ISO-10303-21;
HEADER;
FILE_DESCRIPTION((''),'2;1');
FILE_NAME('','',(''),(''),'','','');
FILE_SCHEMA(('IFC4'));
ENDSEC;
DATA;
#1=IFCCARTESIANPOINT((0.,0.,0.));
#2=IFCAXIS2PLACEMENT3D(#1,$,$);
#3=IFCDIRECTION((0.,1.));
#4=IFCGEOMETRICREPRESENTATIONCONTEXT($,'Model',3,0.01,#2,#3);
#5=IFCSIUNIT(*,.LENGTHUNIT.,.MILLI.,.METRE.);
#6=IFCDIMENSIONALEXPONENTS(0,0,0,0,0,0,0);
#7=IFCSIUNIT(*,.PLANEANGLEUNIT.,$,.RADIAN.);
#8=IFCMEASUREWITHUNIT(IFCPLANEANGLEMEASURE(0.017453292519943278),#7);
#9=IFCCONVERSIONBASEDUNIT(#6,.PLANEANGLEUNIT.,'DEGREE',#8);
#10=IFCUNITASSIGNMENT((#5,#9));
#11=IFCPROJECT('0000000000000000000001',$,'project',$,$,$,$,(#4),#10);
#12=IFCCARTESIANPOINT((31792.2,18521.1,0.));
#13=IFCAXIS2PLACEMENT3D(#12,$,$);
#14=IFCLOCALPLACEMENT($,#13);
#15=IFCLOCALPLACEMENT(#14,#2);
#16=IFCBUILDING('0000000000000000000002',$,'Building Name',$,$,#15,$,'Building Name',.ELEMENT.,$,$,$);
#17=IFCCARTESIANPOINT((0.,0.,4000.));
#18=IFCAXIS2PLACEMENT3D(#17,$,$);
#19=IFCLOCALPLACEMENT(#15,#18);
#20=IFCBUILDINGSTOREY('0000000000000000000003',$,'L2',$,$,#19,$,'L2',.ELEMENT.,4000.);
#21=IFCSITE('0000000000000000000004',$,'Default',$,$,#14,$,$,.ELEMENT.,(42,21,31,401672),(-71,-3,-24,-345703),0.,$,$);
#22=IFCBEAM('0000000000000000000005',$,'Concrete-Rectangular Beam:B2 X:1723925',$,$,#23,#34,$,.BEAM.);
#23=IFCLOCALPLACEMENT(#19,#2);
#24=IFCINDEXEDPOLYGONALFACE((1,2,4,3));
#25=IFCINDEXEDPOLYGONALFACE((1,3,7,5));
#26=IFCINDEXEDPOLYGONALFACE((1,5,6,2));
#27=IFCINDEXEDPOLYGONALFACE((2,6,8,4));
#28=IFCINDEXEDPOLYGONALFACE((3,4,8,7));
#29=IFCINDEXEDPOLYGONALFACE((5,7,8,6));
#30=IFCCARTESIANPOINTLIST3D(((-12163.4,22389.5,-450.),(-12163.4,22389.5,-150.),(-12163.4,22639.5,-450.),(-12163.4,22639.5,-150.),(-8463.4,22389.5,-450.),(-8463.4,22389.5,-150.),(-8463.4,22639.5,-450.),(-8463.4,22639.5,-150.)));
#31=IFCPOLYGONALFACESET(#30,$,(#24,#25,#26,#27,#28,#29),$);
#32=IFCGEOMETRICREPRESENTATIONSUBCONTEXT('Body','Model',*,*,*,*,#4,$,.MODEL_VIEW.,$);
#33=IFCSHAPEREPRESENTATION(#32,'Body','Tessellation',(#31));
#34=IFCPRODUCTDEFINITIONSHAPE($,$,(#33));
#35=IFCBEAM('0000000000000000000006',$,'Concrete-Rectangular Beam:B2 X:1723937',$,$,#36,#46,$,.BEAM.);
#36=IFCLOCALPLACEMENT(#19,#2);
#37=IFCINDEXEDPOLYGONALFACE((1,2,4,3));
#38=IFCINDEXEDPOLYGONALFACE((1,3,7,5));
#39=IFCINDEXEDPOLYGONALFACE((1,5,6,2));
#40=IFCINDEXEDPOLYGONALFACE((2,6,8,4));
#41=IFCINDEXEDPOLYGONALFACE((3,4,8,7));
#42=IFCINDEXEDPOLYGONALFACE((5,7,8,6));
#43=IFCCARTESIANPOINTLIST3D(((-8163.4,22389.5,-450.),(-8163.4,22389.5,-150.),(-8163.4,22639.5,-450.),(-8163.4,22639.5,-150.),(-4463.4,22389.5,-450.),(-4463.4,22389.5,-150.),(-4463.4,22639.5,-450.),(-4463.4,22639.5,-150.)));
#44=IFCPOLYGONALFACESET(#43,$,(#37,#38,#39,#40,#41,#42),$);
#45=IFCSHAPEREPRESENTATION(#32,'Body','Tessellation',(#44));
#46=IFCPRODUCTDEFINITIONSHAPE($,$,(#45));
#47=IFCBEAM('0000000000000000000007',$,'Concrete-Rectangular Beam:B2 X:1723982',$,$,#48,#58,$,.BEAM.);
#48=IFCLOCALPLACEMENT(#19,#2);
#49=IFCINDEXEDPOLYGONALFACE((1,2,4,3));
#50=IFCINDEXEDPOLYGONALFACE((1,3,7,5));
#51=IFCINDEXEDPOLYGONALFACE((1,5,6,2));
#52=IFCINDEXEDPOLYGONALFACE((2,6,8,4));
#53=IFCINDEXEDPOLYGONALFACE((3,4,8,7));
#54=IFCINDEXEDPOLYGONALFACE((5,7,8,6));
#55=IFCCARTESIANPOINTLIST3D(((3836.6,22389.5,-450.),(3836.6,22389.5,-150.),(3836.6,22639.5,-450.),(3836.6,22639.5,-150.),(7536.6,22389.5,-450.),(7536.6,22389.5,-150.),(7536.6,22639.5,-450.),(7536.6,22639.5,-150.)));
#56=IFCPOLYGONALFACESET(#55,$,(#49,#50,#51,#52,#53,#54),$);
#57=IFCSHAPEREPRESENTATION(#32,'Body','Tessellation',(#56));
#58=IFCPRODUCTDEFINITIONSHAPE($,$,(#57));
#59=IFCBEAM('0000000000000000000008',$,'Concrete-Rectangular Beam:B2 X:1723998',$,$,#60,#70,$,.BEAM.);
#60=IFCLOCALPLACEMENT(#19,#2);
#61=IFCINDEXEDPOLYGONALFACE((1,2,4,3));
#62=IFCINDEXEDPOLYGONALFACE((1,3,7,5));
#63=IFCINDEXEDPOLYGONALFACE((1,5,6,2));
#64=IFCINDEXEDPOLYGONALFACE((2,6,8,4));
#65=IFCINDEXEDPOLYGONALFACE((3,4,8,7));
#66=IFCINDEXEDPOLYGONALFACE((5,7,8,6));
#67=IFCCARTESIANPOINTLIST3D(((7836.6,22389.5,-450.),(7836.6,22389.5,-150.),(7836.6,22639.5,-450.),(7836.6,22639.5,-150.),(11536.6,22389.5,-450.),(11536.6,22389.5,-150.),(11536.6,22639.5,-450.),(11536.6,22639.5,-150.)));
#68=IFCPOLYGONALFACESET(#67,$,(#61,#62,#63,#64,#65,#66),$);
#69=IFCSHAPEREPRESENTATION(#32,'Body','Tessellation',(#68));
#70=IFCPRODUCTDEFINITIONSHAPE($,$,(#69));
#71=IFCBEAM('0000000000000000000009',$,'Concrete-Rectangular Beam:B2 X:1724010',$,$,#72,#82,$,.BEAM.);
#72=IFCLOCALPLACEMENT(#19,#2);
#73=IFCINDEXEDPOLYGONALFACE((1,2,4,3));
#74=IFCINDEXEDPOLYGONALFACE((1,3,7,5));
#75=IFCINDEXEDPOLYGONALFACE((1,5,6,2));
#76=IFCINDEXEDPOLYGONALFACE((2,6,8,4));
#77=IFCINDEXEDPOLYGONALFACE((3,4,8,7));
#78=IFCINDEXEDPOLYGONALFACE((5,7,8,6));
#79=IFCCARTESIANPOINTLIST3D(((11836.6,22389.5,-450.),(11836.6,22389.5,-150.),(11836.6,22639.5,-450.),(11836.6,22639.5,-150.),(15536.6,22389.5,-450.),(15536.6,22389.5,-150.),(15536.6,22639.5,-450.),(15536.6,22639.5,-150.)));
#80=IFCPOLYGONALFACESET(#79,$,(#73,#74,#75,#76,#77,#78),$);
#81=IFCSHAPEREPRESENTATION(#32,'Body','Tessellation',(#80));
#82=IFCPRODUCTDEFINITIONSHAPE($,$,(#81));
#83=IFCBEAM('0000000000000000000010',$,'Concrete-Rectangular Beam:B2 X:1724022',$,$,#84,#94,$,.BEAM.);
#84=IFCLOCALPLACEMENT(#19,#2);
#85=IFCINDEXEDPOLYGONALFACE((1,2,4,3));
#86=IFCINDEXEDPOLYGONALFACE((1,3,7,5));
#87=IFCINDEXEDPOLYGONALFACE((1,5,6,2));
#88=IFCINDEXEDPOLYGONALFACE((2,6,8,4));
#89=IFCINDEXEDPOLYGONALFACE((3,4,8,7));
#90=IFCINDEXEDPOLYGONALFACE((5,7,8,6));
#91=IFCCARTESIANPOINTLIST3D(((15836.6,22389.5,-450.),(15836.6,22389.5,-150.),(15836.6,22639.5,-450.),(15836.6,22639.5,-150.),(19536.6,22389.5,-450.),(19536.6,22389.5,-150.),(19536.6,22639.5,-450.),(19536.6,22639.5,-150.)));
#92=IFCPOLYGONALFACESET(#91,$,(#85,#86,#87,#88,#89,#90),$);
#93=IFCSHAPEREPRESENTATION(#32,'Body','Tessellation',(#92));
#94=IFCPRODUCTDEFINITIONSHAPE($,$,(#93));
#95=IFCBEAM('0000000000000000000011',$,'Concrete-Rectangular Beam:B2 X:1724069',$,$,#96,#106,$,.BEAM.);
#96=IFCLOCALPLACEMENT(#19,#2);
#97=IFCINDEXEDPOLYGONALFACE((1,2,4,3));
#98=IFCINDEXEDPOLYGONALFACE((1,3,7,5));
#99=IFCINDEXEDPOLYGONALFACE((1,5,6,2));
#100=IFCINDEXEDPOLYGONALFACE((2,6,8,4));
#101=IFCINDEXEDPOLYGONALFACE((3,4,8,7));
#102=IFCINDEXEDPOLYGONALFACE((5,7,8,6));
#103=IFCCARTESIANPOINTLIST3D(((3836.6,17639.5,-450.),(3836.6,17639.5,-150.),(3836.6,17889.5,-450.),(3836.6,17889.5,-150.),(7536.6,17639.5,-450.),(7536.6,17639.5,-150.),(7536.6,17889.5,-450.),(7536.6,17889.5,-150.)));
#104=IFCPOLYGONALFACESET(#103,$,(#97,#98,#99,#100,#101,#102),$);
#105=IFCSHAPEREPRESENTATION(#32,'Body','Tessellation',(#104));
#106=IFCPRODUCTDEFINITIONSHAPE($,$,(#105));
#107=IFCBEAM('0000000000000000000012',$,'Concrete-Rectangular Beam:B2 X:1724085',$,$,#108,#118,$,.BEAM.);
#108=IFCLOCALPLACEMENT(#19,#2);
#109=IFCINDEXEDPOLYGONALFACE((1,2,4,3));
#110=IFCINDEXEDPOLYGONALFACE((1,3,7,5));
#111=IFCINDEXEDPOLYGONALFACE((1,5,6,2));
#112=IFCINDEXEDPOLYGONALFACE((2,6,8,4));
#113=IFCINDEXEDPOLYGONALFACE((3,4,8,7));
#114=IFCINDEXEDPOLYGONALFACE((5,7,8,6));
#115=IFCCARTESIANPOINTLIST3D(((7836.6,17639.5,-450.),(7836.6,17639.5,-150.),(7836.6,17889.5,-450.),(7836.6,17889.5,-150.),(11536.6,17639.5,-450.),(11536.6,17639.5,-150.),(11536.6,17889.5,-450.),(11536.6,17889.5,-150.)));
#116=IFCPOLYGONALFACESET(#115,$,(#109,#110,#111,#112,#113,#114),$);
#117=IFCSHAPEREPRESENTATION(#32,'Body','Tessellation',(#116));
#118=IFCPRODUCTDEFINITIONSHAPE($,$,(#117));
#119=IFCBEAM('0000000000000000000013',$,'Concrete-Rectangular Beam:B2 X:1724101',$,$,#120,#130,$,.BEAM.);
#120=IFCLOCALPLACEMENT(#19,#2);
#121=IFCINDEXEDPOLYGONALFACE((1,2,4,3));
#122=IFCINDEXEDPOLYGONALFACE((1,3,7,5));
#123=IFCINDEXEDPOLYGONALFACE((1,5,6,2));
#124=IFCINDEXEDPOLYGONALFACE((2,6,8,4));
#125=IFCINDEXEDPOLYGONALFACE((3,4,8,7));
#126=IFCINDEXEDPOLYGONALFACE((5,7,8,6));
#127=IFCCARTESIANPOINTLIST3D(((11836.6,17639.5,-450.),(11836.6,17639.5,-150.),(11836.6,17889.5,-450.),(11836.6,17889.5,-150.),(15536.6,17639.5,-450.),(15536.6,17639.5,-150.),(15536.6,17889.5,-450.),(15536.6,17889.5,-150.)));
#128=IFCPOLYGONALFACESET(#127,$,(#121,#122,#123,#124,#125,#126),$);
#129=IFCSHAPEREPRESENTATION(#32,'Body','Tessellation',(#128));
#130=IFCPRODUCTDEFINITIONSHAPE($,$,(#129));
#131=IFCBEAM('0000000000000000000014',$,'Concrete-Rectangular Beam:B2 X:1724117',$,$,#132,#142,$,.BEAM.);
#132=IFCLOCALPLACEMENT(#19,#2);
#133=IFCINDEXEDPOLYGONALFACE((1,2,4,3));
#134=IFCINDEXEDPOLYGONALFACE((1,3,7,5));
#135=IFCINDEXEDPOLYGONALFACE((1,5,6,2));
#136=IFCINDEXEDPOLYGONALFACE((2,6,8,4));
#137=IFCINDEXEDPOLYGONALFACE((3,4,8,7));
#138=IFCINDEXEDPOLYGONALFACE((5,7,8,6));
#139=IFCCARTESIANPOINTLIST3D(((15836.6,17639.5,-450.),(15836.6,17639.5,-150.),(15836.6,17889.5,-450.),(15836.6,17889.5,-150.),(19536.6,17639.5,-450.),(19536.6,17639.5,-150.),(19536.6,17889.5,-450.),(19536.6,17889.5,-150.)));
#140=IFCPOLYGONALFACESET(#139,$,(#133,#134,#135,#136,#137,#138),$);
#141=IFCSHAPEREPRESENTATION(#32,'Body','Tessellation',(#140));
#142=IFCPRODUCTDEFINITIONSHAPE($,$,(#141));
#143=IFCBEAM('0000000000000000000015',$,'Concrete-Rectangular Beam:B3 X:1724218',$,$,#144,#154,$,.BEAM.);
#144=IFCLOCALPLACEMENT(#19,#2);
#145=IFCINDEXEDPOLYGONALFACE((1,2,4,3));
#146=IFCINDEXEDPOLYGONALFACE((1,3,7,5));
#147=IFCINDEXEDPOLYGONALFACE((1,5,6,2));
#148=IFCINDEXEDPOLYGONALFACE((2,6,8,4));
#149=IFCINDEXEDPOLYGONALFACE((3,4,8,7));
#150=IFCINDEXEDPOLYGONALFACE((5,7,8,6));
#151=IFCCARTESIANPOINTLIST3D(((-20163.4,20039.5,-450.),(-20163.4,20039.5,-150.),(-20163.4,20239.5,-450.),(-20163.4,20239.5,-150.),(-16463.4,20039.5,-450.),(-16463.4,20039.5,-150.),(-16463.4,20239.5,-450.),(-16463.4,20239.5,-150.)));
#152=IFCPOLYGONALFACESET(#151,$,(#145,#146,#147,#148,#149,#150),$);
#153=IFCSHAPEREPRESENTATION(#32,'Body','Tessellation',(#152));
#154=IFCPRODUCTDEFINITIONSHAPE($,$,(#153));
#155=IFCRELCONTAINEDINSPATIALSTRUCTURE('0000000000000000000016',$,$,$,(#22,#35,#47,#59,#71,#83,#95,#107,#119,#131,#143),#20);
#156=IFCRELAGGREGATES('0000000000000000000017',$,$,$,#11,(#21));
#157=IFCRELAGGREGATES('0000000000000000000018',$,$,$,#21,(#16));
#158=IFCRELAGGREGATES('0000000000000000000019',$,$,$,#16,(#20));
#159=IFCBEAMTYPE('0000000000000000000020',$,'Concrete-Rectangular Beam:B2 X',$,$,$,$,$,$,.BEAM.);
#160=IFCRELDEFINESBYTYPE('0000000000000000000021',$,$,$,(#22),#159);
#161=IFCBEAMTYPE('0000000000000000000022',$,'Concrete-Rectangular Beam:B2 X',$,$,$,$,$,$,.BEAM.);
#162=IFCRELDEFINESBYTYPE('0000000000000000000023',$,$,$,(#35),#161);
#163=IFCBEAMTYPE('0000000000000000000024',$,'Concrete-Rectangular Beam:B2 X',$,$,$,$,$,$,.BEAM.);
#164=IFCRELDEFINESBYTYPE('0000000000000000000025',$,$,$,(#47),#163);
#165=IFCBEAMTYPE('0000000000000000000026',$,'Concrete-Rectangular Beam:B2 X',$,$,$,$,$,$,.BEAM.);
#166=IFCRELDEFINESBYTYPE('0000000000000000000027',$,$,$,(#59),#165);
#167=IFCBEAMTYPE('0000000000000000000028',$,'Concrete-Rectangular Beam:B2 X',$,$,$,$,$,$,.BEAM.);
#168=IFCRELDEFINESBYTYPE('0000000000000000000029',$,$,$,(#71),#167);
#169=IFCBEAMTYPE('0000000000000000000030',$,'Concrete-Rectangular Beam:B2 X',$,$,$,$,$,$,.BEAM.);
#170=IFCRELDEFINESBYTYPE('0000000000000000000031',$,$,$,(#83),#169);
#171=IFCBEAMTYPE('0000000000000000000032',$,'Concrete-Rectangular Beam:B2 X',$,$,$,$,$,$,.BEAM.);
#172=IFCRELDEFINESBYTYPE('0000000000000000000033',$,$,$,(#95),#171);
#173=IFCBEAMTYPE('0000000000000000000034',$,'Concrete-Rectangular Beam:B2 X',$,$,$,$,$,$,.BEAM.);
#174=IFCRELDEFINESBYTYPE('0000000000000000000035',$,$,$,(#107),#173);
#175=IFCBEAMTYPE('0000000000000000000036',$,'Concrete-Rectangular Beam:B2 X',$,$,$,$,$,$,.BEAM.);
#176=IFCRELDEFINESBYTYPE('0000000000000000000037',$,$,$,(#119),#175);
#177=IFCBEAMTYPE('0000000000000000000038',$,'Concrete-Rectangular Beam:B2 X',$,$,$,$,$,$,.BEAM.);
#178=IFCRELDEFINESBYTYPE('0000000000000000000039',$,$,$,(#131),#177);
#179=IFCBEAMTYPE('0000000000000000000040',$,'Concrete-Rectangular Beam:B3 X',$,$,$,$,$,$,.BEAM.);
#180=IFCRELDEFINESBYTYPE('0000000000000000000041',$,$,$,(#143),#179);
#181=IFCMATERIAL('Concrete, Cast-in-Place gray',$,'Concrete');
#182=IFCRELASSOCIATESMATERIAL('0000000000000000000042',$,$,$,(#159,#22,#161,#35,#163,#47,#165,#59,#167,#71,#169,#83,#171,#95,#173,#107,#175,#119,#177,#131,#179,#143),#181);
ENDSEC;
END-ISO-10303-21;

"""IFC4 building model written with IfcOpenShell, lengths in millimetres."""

from ifc_helpers import new_model, entity, si_unit, converted_unit, direction, frame, origin, place, context, subcontext, project, spatial, indexed_curve, outline, extrude, source, transform, mapped, material, type_object, type_shapes, element, save


model = new_model("IFC4")

# Units and contexts
model_context = context("Model", 3, precision=0.01, world=origin(), true_north=direction((0.0, 1.0)))
body_context = subcontext(model_context, "Body", "Model", "MODEL_VIEW")
ifc_project = project(units=[si_unit("LENGTHUNIT", "METRE", prefix="MILLI"), converted_unit("PLANEANGLEUNIT", "DEGREE", entity("IfcPlaneAngleMeasure", 0.017453292519943278), si_unit("PLANEANGLEUNIT", "RADIAN"), dimensions=[0, 0, 0, 0, 0, 0, 0])], contexts=[model_context])

# Site, building, storey
site_placement = place(None, frame((31792.2, 18521.1, 0.0)))
site = spatial("IfcSite", under=ifc_project, at=site_placement, Name="Default", CompositionType="ELEMENT", RefLatitude=(42, 21, 31, 401672), RefLongitude=(-71, -3, -24, -345703), RefElevation=0.0)
building_placement = place(site_placement, origin())
building = spatial("IfcBuilding", under=site, at=building_placement, Name="Building Name", LongName="Building Name", CompositionType="ELEMENT")
storey_placement = place(building_placement, frame((0.0, 0.0, 4000.0)))
storey = spatial("IfcBuildingStorey", under=building, at=storey_placement, Name="L2", LongName="L2", CompositionType="ELEMENT", Elevation=4000.0)

# Beams
ifc_material = material(Name="Concrete, Cast-in-Place gray", Category="Concrete")
beam_type_1 = type_object("IfcBeamType", Name="Concrete-Rectangular Beam:B2 X", PredefinedType="BEAM", material=ifc_material)
shared_shape_1 = source(origin(), body_context, "Body", "SweptSolid", [
    extrude(outline(indexed_curve([(-150.0, -125.0), (150.0, -125.0), (150.0, 125.0), (-150.0, 125.0), (-150.0, -125.0)], self_intersect=False)), frame((-12163.4, 22514.5, 3700.0), z_axis=(1.0, 0.0, 0.0), x_axis=(0.0, 0.0, -1.0)), (0.0, 0.0, 1.0), 3700.0),
])
type_shapes(beam_type_1, [shared_shape_1])
beam_1_placement = place(storey_placement, frame((0.0, 0.0, -4000.0)))
element("IfcBeam", 1, at=beam_1_placement, inside=storey, type_object=beam_type_1, material=ifc_material, Name="Concrete-Rectangular Beam:B2 X:1723925", PredefinedType="BEAM", context=body_context, shape_type="MappedRepresentation", body=[
    mapped(shared_shape_1, transform((0.0, 0.0, 0.0), scale=1.0)),
])
beam_type_2 = type_object("IfcBeamType", Name="Concrete-Rectangular Beam:B2 X", PredefinedType="BEAM", material=ifc_material)
shared_shape_2 = source(origin(), body_context, "Body", "SweptSolid", [
    extrude(outline(indexed_curve([(-150.0, -125.0), (150.0, -125.0), (150.0, 125.0), (-150.0, 125.0), (-150.0, -125.0)], self_intersect=False)), frame((-8163.4, 22514.5, 3700.0), z_axis=(1.0, 0.0, 0.0), x_axis=(0.0, 0.0, -1.0)), (0.0, 0.0, 1.0), 3700.0),
])
type_shapes(beam_type_2, [shared_shape_2])
beam_2_placement = place(storey_placement, frame((0.0, 0.0, -4000.0)))
element("IfcBeam", 2, at=beam_2_placement, inside=storey, type_object=beam_type_2, material=ifc_material, Name="Concrete-Rectangular Beam:B2 X:1723937", PredefinedType="BEAM", context=body_context, shape_type="MappedRepresentation", body=[
    mapped(shared_shape_2, transform((0.0, 0.0, 0.0), scale=1.0)),
])
beam_type_3 = type_object("IfcBeamType", Name="Concrete-Rectangular Beam:B2 X", PredefinedType="BEAM", material=ifc_material)
shared_shape_3 = source(origin(), body_context, "Body", "SweptSolid", [
    extrude(outline(indexed_curve([(-150.0, -125.0), (150.0, -125.0), (150.0, 125.0), (-150.0, 125.0), (-150.0, -125.0)], self_intersect=False)), frame((3836.6, 22514.5, 3700.0), z_axis=(1.0, 0.0, 0.0), x_axis=(0.0, 0.0, -1.0)), (0.0, 0.0, 1.0), 3700.0),
])
type_shapes(beam_type_3, [shared_shape_3])
beam_3_placement = place(storey_placement, frame((0.0, 0.0, -4000.0)))
element("IfcBeam", 3, at=beam_3_placement, inside=storey, type_object=beam_type_3, material=ifc_material, Name="Concrete-Rectangular Beam:B2 X:1723982", PredefinedType="BEAM", context=body_context, shape_type="MappedRepresentation", body=[
    mapped(shared_shape_3, transform((0.0, 0.0, 0.0), scale=1.0)),
])
beam_type_4 = type_object("IfcBeamType", Name="Concrete-Rectangular Beam:B2 X", PredefinedType="BEAM", material=ifc_material)
shared_shape_4 = source(origin(), body_context, "Body", "SweptSolid", [
    extrude(outline(indexed_curve([(-150.0, -125.0), (150.0, -125.0), (150.0, 125.0), (-150.0, 125.0), (-150.0, -125.0)], self_intersect=False)), frame((7836.6, 22514.5, 3700.0), z_axis=(1.0, 0.0, 0.0), x_axis=(0.0, 0.0, -1.0)), (0.0, 0.0, 1.0), 3700.0),
])
type_shapes(beam_type_4, [shared_shape_4])
beam_4_placement = place(storey_placement, frame((0.0, 0.0, -4000.0)))
element("IfcBeam", 4, at=beam_4_placement, inside=storey, type_object=beam_type_4, material=ifc_material, Name="Concrete-Rectangular Beam:B2 X:1723998", PredefinedType="BEAM", context=body_context, shape_type="MappedRepresentation", body=[
    mapped(shared_shape_4, transform((0.0, 0.0, 0.0), scale=1.0)),
])
beam_type_5 = type_object("IfcBeamType", Name="Concrete-Rectangular Beam:B2 X", PredefinedType="BEAM", material=ifc_material)
shared_shape_5 = source(origin(), body_context, "Body", "SweptSolid", [
    extrude(outline(indexed_curve([(-150.0, -125.0), (150.0, -125.0), (150.0, 125.0), (-150.0, 125.0), (-150.0, -125.0)], self_intersect=False)), frame((11836.6, 22514.5, 3700.0), z_axis=(1.0, 0.0, 0.0), x_axis=(0.0, 0.0, -1.0)), (0.0, 0.0, 1.0), 3700.0),
])
type_shapes(beam_type_5, [shared_shape_5])
beam_5_placement = place(storey_placement, frame((0.0, 0.0, -4000.0)))
element("IfcBeam", 5, at=beam_5_placement, inside=storey, type_object=beam_type_5, material=ifc_material, Name="Concrete-Rectangular Beam:B2 X:1724010", PredefinedType="BEAM", context=body_context, shape_type="MappedRepresentation", body=[
    mapped(shared_shape_5, transform((0.0, 0.0, 0.0), scale=1.0)),
])
beam_type_6 = type_object("IfcBeamType", Name="Concrete-Rectangular Beam:B2 X", PredefinedType="BEAM", material=ifc_material)
shared_shape_6 = source(origin(), body_context, "Body", "SweptSolid", [
    extrude(outline(indexed_curve([(-150.0, -125.0), (150.0, -125.0), (150.0, 125.0), (-150.0, 125.0), (-150.0, -125.0)], self_intersect=False)), frame((15836.6, 22514.5, 3700.0), z_axis=(1.0, 0.0, 0.0), x_axis=(0.0, 0.0, -1.0)), (0.0, 0.0, 1.0), 3700.0),
])
type_shapes(beam_type_6, [shared_shape_6])
beam_6_placement = place(storey_placement, frame((0.0, 0.0, -4000.0)))
element("IfcBeam", 6, at=beam_6_placement, inside=storey, type_object=beam_type_6, material=ifc_material, Name="Concrete-Rectangular Beam:B2 X:1724022", PredefinedType="BEAM", context=body_context, shape_type="MappedRepresentation", body=[
    mapped(shared_shape_6, transform((0.0, 0.0, 0.0), scale=1.0)),
])
beam_type_7 = type_object("IfcBeamType", Name="Concrete-Rectangular Beam:B2 X", PredefinedType="BEAM", material=ifc_material)
shared_shape_7 = source(origin(), body_context, "Body", "SweptSolid", [
    extrude(outline(indexed_curve([(-150.0, -125.0), (150.0, -125.0), (150.0, 125.0), (-150.0, 125.0), (-150.0, -125.0)], self_intersect=False)), frame((3836.6, 17764.5, 3700.0), z_axis=(1.0, 0.0, 0.0), x_axis=(0.0, 0.0, -1.0)), (0.0, 0.0, 1.0), 3700.0),
])
type_shapes(beam_type_7, [shared_shape_7])
beam_7_placement = place(storey_placement, frame((0.0, 0.0, -4000.0)))
element("IfcBeam", 7, at=beam_7_placement, inside=storey, type_object=beam_type_7, material=ifc_material, Name="Concrete-Rectangular Beam:B2 X:1724069", PredefinedType="BEAM", context=body_context, shape_type="MappedRepresentation", body=[
    mapped(shared_shape_7, transform((0.0, 0.0, 0.0), scale=1.0)),
])
beam_type_8 = type_object("IfcBeamType", Name="Concrete-Rectangular Beam:B2 X", PredefinedType="BEAM", material=ifc_material)
shared_shape_8 = source(origin(), body_context, "Body", "SweptSolid", [
    extrude(outline(indexed_curve([(-150.0, -125.0), (150.0, -125.0), (150.0, 125.0), (-150.0, 125.0), (-150.0, -125.0)], self_intersect=False)), frame((7836.6, 17764.5, 3700.0), z_axis=(1.0, 0.0, 0.0), x_axis=(0.0, 0.0, -1.0)), (0.0, 0.0, 1.0), 3700.0),
])
type_shapes(beam_type_8, [shared_shape_8])
beam_8_placement = place(storey_placement, frame((0.0, 0.0, -4000.0)))
element("IfcBeam", 8, at=beam_8_placement, inside=storey, type_object=beam_type_8, material=ifc_material, Name="Concrete-Rectangular Beam:B2 X:1724085", PredefinedType="BEAM", context=body_context, shape_type="MappedRepresentation", body=[
    mapped(shared_shape_8, transform((0.0, 0.0, 0.0), scale=1.0)),
])
beam_type_9 = type_object("IfcBeamType", Name="Concrete-Rectangular Beam:B2 X", PredefinedType="BEAM", material=ifc_material)
shared_shape_9 = source(origin(), body_context, "Body", "SweptSolid", [
    extrude(outline(indexed_curve([(-150.0, -125.0), (150.0, -125.0), (150.0, 125.0), (-150.0, 125.0), (-150.0, -125.0)], self_intersect=False)), frame((11836.6, 17764.5, 3700.0), z_axis=(1.0, 0.0, 0.0), x_axis=(0.0, 0.0, -1.0)), (0.0, 0.0, 1.0), 3700.0),
])
type_shapes(beam_type_9, [shared_shape_9])
beam_9_placement = place(storey_placement, frame((0.0, 0.0, -4000.0)))
element("IfcBeam", 9, at=beam_9_placement, inside=storey, type_object=beam_type_9, material=ifc_material, Name="Concrete-Rectangular Beam:B2 X:1724101", PredefinedType="BEAM", context=body_context, shape_type="MappedRepresentation", body=[
    mapped(shared_shape_9, transform((0.0, 0.0, 0.0), scale=1.0)),
])
beam_type_10 = type_object("IfcBeamType", Name="Concrete-Rectangular Beam:B2 X", PredefinedType="BEAM", material=ifc_material)
shared_shape_10 = source(origin(), body_context, "Body", "SweptSolid", [
    extrude(outline(indexed_curve([(-150.0, -125.0), (150.0, -125.0), (150.0, 125.0), (-150.0, 125.0), (-150.0, -125.0)], self_intersect=False)), frame((15836.6, 17764.5, 3700.0), z_axis=(1.0, 0.0, 0.0), x_axis=(0.0, 0.0, -1.0)), (0.0, 0.0, 1.0), 3700.0),
])
type_shapes(beam_type_10, [shared_shape_10])
beam_10_placement = place(storey_placement, frame((0.0, 0.0, -4000.0)))
element("IfcBeam", 10, at=beam_10_placement, inside=storey, type_object=beam_type_10, material=ifc_material, Name="Concrete-Rectangular Beam:B2 X:1724117", PredefinedType="BEAM", context=body_context, shape_type="MappedRepresentation", body=[
    mapped(shared_shape_10, transform((0.0, 0.0, 0.0), scale=1.0)),
])
beam_type_11 = type_object("IfcBeamType", Name="Concrete-Rectangular Beam:B3 X", PredefinedType="BEAM", material=ifc_material)
shared_shape_11 = source(origin(), body_context, "Body", "SweptSolid", [
    extrude(outline(indexed_curve([(-150.0, -100.0), (150.0, -100.0), (150.0, 100.0), (-150.0, 100.0), (-150.0, -100.0)], self_intersect=False)), frame((-20163.4, 20139.5, 3700.0), z_axis=(1.0, 0.0, 0.0), x_axis=(0.0, 0.0, -1.0)), (0.0, 0.0, 1.0), 3700.0),
])
type_shapes(beam_type_11, [shared_shape_11])
beam_11_placement = place(storey_placement, frame((0.0, 0.0, -4000.0)))
element("IfcBeam", 11, at=beam_11_placement, inside=storey, type_object=beam_type_11, material=ifc_material, Name="Concrete-Rectangular Beam:B3 X:1724218", PredefinedType="BEAM", context=body_context, shape_type="MappedRepresentation", body=[
    mapped(shared_shape_11, transform((0.0, 0.0, 0.0), scale=1.0)),
])

save(model, "model.ifc")
